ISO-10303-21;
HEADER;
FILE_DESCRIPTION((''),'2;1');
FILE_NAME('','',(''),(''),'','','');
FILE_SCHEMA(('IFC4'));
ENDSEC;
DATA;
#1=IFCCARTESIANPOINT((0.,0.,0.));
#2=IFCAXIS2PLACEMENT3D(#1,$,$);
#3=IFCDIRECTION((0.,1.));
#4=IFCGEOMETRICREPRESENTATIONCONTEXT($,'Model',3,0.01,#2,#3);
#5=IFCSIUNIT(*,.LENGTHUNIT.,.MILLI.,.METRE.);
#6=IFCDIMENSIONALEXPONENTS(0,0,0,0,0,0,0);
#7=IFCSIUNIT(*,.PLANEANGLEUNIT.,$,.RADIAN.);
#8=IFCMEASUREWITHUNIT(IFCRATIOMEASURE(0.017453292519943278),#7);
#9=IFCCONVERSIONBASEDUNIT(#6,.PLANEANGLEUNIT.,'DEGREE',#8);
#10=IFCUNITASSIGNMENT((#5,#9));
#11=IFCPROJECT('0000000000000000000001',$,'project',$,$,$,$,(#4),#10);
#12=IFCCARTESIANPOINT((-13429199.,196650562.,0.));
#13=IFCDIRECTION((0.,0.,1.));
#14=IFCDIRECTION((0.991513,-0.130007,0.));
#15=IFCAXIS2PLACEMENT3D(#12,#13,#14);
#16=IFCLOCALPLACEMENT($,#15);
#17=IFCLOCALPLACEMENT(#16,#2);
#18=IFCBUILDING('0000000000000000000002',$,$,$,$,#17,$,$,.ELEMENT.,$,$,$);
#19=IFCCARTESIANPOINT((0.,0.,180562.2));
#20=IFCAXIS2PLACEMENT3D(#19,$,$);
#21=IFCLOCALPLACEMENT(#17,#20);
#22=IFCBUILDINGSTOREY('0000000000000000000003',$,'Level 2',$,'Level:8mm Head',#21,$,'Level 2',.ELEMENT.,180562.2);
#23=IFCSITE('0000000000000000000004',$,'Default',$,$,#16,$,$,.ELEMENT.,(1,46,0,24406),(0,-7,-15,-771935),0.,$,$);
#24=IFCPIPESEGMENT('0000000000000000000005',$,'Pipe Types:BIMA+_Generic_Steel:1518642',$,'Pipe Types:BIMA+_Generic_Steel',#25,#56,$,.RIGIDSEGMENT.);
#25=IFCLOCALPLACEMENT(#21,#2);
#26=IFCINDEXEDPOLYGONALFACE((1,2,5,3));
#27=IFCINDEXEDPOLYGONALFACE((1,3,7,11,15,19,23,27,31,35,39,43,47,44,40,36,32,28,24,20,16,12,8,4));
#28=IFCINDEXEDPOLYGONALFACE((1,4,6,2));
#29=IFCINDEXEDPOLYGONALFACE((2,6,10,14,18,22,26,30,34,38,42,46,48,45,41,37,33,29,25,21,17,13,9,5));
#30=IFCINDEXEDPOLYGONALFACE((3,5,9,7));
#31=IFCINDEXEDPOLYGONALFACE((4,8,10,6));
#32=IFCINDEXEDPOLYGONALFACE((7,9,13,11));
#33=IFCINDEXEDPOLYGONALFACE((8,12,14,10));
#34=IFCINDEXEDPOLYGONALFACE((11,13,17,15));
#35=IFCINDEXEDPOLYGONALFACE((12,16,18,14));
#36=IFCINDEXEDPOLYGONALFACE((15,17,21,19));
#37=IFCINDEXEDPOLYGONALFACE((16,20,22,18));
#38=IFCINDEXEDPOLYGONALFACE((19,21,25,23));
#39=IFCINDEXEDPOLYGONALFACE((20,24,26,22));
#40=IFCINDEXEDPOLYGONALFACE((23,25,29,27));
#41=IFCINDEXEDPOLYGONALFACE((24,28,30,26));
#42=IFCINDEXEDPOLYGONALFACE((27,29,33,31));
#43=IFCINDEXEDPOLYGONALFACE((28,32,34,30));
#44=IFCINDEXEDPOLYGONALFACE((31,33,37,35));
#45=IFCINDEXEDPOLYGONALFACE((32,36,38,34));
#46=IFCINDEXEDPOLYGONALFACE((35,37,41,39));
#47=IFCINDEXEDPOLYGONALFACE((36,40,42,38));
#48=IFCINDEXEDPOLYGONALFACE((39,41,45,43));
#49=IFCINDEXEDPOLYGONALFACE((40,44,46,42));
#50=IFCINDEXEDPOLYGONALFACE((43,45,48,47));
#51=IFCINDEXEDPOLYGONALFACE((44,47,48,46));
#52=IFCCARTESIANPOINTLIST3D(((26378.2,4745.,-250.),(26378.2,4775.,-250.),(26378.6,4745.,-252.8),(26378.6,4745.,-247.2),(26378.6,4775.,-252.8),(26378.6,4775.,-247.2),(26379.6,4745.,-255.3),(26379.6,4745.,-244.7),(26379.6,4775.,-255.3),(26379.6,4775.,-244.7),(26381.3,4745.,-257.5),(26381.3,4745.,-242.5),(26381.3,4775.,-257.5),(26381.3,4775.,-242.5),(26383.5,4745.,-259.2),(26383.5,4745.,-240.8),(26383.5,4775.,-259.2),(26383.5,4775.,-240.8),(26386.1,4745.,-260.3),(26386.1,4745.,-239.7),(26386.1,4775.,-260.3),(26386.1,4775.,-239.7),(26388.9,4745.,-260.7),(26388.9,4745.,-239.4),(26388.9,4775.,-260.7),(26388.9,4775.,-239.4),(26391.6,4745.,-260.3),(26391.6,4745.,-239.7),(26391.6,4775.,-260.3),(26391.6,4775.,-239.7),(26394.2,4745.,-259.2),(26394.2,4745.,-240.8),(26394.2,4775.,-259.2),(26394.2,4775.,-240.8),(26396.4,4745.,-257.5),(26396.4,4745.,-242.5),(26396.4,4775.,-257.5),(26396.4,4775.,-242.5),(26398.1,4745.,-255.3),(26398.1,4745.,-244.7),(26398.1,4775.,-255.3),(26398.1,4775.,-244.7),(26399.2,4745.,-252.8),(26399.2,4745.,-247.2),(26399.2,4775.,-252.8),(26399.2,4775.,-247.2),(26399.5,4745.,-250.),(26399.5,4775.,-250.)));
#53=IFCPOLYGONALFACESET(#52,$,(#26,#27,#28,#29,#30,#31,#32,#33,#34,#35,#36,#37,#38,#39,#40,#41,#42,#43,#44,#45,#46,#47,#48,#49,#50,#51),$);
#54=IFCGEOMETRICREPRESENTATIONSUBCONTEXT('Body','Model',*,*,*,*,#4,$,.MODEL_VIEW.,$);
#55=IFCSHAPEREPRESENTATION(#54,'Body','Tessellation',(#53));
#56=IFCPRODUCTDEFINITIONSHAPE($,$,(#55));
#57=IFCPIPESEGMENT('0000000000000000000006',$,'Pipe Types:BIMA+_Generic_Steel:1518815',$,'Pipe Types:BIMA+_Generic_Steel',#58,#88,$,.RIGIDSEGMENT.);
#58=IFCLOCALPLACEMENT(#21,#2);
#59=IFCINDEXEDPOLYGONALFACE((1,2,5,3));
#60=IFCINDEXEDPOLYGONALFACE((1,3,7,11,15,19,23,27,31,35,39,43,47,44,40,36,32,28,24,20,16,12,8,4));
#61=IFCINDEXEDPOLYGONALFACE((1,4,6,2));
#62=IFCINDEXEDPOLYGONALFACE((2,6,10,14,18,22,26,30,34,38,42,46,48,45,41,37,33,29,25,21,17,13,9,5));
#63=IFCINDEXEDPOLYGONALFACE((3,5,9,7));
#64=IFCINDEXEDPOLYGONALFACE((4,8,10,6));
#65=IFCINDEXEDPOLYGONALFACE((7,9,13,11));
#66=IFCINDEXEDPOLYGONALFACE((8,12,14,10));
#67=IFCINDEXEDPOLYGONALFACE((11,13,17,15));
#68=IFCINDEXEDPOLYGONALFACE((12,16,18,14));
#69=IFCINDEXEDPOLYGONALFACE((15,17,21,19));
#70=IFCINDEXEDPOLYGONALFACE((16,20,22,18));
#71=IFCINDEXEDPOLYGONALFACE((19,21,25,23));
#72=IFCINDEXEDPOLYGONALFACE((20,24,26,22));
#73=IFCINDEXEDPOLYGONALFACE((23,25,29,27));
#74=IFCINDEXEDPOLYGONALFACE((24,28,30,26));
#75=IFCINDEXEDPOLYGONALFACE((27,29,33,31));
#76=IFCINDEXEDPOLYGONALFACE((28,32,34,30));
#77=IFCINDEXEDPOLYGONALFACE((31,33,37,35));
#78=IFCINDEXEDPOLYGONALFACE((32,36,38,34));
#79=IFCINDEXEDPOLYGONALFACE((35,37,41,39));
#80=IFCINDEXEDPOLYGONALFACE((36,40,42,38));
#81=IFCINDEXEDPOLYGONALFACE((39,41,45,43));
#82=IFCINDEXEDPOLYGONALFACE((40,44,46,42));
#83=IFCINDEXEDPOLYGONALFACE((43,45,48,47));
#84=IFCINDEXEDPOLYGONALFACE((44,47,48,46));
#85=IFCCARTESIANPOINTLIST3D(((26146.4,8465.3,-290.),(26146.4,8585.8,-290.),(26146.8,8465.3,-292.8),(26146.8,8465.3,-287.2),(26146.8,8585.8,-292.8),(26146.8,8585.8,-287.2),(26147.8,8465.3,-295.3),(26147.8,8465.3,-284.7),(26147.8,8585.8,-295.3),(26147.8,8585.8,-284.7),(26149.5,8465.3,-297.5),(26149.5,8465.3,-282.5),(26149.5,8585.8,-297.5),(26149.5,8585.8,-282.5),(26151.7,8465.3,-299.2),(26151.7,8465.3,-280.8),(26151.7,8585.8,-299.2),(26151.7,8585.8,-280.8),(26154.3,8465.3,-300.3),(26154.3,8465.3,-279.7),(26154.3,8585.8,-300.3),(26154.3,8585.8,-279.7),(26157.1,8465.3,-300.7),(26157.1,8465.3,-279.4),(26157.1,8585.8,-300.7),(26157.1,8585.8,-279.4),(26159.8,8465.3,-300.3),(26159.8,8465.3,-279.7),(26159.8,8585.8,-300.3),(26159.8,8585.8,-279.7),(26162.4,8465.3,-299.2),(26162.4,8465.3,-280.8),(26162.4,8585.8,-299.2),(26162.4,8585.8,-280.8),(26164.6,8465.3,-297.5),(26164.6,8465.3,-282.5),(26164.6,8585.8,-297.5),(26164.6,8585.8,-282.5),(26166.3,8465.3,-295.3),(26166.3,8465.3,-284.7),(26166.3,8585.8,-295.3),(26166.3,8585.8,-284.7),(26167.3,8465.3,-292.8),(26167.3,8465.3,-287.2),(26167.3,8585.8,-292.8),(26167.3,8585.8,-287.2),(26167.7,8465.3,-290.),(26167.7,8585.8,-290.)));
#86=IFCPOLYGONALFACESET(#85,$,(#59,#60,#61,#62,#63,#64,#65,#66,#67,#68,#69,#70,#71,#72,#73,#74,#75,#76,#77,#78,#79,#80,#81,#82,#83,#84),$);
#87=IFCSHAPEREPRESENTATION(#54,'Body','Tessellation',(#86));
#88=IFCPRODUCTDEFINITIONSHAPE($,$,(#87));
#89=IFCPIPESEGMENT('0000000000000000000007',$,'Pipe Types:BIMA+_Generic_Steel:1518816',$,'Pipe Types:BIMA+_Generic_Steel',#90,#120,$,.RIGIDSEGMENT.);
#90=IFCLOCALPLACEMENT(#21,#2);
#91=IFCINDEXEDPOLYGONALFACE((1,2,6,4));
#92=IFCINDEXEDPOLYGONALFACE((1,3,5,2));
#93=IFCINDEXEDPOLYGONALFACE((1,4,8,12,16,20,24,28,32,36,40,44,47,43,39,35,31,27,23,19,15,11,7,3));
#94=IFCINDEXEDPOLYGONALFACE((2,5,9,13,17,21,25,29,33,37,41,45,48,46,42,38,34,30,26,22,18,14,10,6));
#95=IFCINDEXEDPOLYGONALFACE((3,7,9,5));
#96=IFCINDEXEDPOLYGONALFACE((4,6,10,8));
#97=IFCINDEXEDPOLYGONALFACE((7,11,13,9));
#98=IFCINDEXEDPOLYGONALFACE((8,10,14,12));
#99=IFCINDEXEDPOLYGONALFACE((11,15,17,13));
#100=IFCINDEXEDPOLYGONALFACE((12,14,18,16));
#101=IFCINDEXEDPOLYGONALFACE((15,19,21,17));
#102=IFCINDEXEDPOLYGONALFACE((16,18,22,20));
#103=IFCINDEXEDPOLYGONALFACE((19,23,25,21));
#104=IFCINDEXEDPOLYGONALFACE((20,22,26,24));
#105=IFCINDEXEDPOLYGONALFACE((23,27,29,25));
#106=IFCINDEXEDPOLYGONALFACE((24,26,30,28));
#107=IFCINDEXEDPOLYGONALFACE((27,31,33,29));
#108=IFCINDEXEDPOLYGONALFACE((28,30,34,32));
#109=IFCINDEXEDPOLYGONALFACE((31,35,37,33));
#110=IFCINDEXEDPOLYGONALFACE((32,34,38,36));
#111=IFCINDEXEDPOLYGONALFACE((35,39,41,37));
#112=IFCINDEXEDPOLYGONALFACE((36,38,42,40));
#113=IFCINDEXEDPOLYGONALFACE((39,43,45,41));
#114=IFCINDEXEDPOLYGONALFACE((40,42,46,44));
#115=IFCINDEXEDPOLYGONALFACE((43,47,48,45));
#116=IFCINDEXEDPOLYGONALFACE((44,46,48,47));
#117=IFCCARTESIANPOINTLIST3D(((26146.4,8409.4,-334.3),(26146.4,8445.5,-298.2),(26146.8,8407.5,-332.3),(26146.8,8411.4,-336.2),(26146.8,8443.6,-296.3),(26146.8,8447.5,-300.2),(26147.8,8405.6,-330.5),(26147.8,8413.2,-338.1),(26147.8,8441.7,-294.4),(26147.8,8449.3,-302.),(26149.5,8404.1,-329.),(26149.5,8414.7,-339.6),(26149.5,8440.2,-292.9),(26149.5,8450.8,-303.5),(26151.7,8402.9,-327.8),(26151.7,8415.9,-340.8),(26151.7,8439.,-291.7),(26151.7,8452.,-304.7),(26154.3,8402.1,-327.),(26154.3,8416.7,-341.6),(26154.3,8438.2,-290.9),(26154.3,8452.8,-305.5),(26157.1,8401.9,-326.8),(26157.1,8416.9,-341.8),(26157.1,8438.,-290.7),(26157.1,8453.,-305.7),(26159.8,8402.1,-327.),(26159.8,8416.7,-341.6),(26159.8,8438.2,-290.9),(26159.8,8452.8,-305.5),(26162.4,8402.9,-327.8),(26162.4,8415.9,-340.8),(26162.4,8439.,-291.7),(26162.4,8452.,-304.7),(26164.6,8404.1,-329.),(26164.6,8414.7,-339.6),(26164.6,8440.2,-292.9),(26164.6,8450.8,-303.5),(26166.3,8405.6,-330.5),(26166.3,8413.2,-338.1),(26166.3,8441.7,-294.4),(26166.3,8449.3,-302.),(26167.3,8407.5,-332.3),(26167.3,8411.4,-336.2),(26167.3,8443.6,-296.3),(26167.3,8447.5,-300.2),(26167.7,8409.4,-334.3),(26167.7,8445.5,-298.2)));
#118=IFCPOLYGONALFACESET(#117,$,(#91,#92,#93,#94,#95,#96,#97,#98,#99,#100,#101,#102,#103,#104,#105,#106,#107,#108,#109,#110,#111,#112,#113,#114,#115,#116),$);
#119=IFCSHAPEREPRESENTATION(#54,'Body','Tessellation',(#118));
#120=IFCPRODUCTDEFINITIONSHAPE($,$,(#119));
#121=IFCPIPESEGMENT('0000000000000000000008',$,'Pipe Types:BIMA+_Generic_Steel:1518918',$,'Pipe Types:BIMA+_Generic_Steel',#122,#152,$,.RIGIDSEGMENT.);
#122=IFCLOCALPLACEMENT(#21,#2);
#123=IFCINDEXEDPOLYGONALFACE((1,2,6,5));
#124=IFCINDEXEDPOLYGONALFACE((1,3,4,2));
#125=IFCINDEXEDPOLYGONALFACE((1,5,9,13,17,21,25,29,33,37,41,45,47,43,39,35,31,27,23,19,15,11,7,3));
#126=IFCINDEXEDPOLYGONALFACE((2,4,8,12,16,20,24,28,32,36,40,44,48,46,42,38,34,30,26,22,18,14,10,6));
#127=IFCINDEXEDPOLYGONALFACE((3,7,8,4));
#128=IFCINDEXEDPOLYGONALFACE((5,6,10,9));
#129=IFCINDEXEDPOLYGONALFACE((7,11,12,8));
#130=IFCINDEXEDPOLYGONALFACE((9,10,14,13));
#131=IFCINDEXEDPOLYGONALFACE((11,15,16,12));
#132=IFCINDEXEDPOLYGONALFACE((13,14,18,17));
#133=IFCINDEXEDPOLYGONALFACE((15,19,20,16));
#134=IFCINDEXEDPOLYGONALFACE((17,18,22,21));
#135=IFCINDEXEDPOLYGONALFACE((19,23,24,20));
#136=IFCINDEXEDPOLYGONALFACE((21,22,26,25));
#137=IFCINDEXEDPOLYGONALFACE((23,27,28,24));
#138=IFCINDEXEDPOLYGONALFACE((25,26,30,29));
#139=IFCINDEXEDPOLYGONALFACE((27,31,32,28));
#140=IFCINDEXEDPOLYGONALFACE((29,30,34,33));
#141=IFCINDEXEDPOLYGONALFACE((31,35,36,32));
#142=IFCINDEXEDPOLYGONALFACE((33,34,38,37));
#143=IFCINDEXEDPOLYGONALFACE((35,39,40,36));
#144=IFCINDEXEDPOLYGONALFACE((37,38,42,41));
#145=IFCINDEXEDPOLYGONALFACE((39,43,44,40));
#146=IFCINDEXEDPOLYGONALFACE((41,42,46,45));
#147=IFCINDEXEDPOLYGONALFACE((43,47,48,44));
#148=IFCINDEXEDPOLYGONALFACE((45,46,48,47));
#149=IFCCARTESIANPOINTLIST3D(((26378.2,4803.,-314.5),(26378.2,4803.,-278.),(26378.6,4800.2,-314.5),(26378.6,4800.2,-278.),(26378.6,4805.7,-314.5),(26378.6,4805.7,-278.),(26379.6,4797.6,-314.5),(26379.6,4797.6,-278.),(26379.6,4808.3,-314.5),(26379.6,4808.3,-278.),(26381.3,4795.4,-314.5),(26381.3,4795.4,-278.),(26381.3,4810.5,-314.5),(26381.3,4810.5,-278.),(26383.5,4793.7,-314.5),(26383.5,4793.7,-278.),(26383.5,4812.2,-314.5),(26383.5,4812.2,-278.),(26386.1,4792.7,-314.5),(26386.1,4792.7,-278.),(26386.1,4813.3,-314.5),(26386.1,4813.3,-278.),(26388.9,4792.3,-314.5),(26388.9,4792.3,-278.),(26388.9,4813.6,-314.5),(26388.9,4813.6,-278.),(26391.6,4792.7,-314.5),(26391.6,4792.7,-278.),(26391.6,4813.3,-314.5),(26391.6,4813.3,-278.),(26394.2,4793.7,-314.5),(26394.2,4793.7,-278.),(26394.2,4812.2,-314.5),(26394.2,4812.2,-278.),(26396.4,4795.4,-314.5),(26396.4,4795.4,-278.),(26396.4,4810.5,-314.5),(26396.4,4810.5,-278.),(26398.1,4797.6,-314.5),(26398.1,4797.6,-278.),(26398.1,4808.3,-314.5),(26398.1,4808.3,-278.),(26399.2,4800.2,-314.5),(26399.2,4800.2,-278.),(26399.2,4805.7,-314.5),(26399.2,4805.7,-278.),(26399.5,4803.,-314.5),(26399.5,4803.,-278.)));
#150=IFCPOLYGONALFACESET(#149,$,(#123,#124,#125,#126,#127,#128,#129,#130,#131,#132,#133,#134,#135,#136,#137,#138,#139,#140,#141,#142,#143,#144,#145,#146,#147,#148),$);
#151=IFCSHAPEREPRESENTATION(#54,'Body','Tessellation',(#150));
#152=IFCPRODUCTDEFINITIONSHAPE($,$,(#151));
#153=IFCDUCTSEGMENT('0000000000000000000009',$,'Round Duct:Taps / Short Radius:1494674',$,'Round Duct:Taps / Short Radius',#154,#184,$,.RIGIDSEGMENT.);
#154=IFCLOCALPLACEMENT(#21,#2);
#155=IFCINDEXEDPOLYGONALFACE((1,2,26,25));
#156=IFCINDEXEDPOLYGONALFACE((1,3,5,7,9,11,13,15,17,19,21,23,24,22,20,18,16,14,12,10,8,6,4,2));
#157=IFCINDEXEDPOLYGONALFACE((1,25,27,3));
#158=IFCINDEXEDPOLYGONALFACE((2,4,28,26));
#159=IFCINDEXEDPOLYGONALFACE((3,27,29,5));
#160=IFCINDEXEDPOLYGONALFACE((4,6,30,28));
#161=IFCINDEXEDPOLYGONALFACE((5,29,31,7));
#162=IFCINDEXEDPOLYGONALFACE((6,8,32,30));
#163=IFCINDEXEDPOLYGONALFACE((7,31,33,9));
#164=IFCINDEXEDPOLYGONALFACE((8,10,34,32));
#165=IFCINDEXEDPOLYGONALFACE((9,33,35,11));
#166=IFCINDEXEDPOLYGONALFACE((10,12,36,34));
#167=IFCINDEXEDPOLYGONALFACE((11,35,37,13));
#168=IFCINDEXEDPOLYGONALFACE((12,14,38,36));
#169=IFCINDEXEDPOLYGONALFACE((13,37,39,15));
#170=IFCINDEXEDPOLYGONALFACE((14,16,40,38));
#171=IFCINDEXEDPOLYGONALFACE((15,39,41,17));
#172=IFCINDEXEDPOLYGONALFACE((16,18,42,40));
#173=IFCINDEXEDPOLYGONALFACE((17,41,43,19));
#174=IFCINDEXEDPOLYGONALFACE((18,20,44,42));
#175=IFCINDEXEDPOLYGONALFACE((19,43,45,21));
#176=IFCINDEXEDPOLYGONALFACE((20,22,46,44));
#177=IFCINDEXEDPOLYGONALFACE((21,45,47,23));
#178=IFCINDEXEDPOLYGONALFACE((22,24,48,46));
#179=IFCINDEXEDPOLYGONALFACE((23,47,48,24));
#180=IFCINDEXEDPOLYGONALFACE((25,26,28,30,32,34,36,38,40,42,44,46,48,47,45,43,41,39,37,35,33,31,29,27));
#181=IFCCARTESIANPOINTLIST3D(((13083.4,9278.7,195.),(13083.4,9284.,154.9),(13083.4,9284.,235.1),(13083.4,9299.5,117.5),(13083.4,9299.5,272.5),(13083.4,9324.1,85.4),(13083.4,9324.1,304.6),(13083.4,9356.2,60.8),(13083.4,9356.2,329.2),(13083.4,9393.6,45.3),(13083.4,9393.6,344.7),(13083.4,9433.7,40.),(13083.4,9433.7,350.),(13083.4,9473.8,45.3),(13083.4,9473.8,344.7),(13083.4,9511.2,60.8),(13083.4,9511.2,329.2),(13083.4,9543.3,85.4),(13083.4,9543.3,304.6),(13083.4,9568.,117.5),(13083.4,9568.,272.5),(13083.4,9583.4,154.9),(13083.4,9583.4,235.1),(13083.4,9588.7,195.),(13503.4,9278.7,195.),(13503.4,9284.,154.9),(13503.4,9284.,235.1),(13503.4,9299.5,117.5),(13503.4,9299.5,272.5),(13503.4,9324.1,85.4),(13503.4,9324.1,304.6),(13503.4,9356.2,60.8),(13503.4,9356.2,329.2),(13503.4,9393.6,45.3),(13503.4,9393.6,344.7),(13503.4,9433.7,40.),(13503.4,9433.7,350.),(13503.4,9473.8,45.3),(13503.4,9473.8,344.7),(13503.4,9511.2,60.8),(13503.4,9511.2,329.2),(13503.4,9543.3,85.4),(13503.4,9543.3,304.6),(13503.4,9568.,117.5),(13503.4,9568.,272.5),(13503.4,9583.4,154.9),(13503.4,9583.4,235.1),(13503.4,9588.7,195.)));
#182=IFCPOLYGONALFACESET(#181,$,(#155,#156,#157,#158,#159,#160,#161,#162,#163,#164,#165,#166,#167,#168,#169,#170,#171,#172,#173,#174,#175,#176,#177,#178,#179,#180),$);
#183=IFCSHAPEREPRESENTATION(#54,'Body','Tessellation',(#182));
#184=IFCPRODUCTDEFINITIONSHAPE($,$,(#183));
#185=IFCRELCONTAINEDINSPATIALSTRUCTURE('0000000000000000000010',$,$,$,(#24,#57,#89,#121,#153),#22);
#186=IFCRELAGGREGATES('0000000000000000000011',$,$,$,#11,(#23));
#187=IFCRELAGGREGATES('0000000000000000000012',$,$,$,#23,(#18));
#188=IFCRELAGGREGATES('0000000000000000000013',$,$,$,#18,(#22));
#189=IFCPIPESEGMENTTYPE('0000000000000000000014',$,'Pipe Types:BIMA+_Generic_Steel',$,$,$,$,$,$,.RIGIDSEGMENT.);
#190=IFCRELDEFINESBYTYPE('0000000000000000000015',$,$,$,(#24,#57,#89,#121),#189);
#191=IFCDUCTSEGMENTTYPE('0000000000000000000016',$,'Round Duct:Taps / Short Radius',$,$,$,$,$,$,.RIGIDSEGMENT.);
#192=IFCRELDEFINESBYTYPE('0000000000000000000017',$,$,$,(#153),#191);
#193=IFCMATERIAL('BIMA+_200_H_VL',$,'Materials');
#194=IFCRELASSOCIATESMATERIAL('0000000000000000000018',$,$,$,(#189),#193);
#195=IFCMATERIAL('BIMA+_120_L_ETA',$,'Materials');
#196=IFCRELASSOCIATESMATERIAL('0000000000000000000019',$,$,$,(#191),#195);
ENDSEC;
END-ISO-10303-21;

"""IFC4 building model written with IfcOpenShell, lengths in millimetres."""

from ifc_helpers import new_model, entity, si_unit, converted_unit, direction, frame, origin, place, context, subcontext, project, spatial, arc, indexed_curve, outline, extrude, material, type_object, element, save


model = new_model("IFC4")

# Units and contexts
model_context = context("Model", 3, precision=0.01, world=origin(), true_north=direction((0.0, 1.0)))
body_context = subcontext(model_context, "Body", "Model", "MODEL_VIEW")
ifc_project = project(units=[si_unit("LENGTHUNIT", "METRE", prefix="MILLI"), converted_unit("PLANEANGLEUNIT", "DEGREE", entity("IfcRatioMeasure", 0.017453292519943278), si_unit("PLANEANGLEUNIT", "RADIAN"), dimensions=[0, 0, 0, 0, 0, 0, 0])], contexts=[model_context])

# Site, building, storey
site_placement = place(None, frame((-13429199.0, 196650562.0, 0.0), z_axis=(0.0, 0.0, 1.0), x_axis=(0.991513, -0.130007, 0.0)))
site = spatial("IfcSite", under=ifc_project, at=site_placement, Name="Default", CompositionType="ELEMENT", RefLatitude=(1, 46, 0, 24406), RefLongitude=(0, -7, -15, -771935), RefElevation=0.0)
building_placement = place(site_placement, origin())
building = spatial("IfcBuilding", under=site, at=building_placement, CompositionType="ELEMENT")
storey_placement = place(building_placement, frame((0.0, 0.0, 180562.2)))
storey = spatial("IfcBuildingStorey", under=building, at=storey_placement, Name="Level 2", ObjectType="Level:8mm Head", LongName="Level 2", CompositionType="ELEMENT", Elevation=180562.2)

# Pipe segments
ifc_material_1 = material(Name="BIMA+_200_H_VL", Category="Materials")
pipe_segment_type = type_object("IfcPipeSegmentType", Name="Pipe Types:BIMA+_Generic_Steel", PredefinedType="RIGIDSEGMENT", material=ifc_material_1)
pipe_segment_1_placement = place(storey_placement, frame((26376.6, 4745.0, -262.2)))
element("IfcPipeSegment", 1, at=pipe_segment_1_placement, inside=storey, type_object=pipe_segment_type, Name="Pipe Types:BIMA+_Generic_Steel:1518642", ObjectType="Pipe Types:BIMA+_Generic_Steel", PredefinedType="RIGIDSEGMENT", context=body_context, shape_type="SweptSolid", body=[
    extrude(outline(indexed_curve([(10.7, 0.0), (7.5, 7.5), (0.0, 10.6), (-7.5, 7.5), (-10.7, 0.0), (-7.5, -7.5), (0.0, -10.7), (7.5, -7.5)], segments=[arc(1, 2, 3), arc(3, 4, 5), arc(5, 6, 7), arc(7, 8, 1)], self_intersect=False)), frame((12.2, 0.0, 12.2), z_axis=(0.0, 1.0, 0.0), x_axis=(1.0, 0.0, 0.0)), (0.0, 0.0, 1.0), 30.0),
])
pipe_segment_2_placement = place(storey_placement, frame((26144.8, 8465.3, -302.2)))
element("IfcPipeSegment", 2, at=pipe_segment_2_placement, inside=storey, type_object=pipe_segment_type, Name="Pipe Types:BIMA+_Generic_Steel:1518815", ObjectType="Pipe Types:BIMA+_Generic_Steel", PredefinedType="RIGIDSEGMENT", context=body_context, shape_type="SweptSolid", body=[
    extrude(outline(indexed_curve([(10.7, 0.0), (7.5, 7.5), (0.0, 10.7), (-7.5, 7.5), (-10.7, 0.0), (-7.5, -7.5), (0.0, -10.7), (7.5, -7.5)], segments=[arc(1, 2, 3), arc(3, 4, 5), arc(5, 6, 7), arc(7, 8, 1)], self_intersect=False)), frame((12.2, 0.0, 12.2), z_axis=(0.0, 1.0, 0.0), x_axis=(-1.0, 0.0, 0.0)), (0.0, 0.0, 1.0), 120.5),
])
pipe_segment_3_placement = place(storey_placement, frame((26144.8, 8400.3, -343.4)))
element("IfcPipeSegment", 3, at=pipe_segment_3_placement, inside=storey, type_object=pipe_segment_type, Name="Pipe Types:BIMA+_Generic_Steel:1518816", ObjectType="Pipe Types:BIMA+_Generic_Steel", PredefinedType="RIGIDSEGMENT", context=body_context, shape_type="SweptSolid", body=[
    extrude(outline(indexed_curve([(10.7, 0.0), (7.5, 7.5), (0.0, 10.7), (-7.5, 7.5), (-10.7, 0.0), (-7.5, -7.5), (0.0, -10.7), (7.5, -7.5)], segments=[arc(1, 2, 3), arc(3, 4, 5), arc(5, 6, 7), arc(7, 8, 1)], self_intersect=False)), frame((12.2, 9.1, 9.1), z_axis=(0.0, 0.707107, 0.707107), x_axis=(-1.0, 0.0, 0.0)), (0.0, 0.0, 1.0), 51.1),
])
pipe_segment_4_placement = place(storey_placement, frame((26376.6, 4790.7, -314.5)))
element("IfcPipeSegment", 4, at=pipe_segment_4_placement, inside=storey, type_object=pipe_segment_type, Name="Pipe Types:BIMA+_Generic_Steel:1518918", ObjectType="Pipe Types:BIMA+_Generic_Steel", PredefinedType="RIGIDSEGMENT", context=body_context, shape_type="SweptSolid", body=[
    extrude(outline(indexed_curve([(10.7, 0.0), (7.5, 7.5), (0.0, 10.6), (-7.5, 7.5), (-10.7, 0.0), (-7.5, -7.5), (0.0, -10.6), (7.5, -7.5)], segments=[arc(1, 2, 3), arc(3, 4, 5), arc(5, 6, 7), arc(7, 8, 1)], self_intersect=False)), frame((12.2, 12.2, 0.0), z_axis=(0.0, 0.0, 1.0), x_axis=(-1.0, 0.0, 0.0)), (0.0, 0.0, 1.0), 36.5),
])

# Duct segment
ifc_material_2 = material(Name="BIMA+_120_L_ETA", Category="Materials")
duct_segment_type_1 = type_object("IfcDuctSegmentType", Name="Round Duct:Taps / Short Radius", PredefinedType="RIGIDSEGMENT", material=ifc_material_2)
duct_segment_1_placement = place(storey_placement, frame((13083.4, 9277.1, 38.4)))
element("IfcDuctSegment", 5, at=duct_segment_1_placement, inside=storey, type_object=duct_segment_type_1, Name="Round Duct:Taps / Short Radius:1494674", ObjectType="Round Duct:Taps / Short Radius", PredefinedType="RIGIDSEGMENT", context=body_context, shape_type="SweptSolid", body=[
    extrude(outline(indexed_curve([(155.0, 0.0), (109.6, 109.6), (0.0, 155.0), (-109.6, 109.6), (-155.0, 0.0), (-109.6, -109.6), (0.0, -155.0), (109.6, -109.6)], segments=[arc(1, 2, 3), arc(3, 4, 5), arc(5, 6, 7), arc(7, 8, 1)], self_intersect=False)), frame((0.0, 156.6, 156.6), z_axis=(1.0, 0.0, 0.0), x_axis=(0.0, -1.0, 0.0)), (0.0, 0.0, 1.0), 420.0),
])

save(model, "model.ifc")
